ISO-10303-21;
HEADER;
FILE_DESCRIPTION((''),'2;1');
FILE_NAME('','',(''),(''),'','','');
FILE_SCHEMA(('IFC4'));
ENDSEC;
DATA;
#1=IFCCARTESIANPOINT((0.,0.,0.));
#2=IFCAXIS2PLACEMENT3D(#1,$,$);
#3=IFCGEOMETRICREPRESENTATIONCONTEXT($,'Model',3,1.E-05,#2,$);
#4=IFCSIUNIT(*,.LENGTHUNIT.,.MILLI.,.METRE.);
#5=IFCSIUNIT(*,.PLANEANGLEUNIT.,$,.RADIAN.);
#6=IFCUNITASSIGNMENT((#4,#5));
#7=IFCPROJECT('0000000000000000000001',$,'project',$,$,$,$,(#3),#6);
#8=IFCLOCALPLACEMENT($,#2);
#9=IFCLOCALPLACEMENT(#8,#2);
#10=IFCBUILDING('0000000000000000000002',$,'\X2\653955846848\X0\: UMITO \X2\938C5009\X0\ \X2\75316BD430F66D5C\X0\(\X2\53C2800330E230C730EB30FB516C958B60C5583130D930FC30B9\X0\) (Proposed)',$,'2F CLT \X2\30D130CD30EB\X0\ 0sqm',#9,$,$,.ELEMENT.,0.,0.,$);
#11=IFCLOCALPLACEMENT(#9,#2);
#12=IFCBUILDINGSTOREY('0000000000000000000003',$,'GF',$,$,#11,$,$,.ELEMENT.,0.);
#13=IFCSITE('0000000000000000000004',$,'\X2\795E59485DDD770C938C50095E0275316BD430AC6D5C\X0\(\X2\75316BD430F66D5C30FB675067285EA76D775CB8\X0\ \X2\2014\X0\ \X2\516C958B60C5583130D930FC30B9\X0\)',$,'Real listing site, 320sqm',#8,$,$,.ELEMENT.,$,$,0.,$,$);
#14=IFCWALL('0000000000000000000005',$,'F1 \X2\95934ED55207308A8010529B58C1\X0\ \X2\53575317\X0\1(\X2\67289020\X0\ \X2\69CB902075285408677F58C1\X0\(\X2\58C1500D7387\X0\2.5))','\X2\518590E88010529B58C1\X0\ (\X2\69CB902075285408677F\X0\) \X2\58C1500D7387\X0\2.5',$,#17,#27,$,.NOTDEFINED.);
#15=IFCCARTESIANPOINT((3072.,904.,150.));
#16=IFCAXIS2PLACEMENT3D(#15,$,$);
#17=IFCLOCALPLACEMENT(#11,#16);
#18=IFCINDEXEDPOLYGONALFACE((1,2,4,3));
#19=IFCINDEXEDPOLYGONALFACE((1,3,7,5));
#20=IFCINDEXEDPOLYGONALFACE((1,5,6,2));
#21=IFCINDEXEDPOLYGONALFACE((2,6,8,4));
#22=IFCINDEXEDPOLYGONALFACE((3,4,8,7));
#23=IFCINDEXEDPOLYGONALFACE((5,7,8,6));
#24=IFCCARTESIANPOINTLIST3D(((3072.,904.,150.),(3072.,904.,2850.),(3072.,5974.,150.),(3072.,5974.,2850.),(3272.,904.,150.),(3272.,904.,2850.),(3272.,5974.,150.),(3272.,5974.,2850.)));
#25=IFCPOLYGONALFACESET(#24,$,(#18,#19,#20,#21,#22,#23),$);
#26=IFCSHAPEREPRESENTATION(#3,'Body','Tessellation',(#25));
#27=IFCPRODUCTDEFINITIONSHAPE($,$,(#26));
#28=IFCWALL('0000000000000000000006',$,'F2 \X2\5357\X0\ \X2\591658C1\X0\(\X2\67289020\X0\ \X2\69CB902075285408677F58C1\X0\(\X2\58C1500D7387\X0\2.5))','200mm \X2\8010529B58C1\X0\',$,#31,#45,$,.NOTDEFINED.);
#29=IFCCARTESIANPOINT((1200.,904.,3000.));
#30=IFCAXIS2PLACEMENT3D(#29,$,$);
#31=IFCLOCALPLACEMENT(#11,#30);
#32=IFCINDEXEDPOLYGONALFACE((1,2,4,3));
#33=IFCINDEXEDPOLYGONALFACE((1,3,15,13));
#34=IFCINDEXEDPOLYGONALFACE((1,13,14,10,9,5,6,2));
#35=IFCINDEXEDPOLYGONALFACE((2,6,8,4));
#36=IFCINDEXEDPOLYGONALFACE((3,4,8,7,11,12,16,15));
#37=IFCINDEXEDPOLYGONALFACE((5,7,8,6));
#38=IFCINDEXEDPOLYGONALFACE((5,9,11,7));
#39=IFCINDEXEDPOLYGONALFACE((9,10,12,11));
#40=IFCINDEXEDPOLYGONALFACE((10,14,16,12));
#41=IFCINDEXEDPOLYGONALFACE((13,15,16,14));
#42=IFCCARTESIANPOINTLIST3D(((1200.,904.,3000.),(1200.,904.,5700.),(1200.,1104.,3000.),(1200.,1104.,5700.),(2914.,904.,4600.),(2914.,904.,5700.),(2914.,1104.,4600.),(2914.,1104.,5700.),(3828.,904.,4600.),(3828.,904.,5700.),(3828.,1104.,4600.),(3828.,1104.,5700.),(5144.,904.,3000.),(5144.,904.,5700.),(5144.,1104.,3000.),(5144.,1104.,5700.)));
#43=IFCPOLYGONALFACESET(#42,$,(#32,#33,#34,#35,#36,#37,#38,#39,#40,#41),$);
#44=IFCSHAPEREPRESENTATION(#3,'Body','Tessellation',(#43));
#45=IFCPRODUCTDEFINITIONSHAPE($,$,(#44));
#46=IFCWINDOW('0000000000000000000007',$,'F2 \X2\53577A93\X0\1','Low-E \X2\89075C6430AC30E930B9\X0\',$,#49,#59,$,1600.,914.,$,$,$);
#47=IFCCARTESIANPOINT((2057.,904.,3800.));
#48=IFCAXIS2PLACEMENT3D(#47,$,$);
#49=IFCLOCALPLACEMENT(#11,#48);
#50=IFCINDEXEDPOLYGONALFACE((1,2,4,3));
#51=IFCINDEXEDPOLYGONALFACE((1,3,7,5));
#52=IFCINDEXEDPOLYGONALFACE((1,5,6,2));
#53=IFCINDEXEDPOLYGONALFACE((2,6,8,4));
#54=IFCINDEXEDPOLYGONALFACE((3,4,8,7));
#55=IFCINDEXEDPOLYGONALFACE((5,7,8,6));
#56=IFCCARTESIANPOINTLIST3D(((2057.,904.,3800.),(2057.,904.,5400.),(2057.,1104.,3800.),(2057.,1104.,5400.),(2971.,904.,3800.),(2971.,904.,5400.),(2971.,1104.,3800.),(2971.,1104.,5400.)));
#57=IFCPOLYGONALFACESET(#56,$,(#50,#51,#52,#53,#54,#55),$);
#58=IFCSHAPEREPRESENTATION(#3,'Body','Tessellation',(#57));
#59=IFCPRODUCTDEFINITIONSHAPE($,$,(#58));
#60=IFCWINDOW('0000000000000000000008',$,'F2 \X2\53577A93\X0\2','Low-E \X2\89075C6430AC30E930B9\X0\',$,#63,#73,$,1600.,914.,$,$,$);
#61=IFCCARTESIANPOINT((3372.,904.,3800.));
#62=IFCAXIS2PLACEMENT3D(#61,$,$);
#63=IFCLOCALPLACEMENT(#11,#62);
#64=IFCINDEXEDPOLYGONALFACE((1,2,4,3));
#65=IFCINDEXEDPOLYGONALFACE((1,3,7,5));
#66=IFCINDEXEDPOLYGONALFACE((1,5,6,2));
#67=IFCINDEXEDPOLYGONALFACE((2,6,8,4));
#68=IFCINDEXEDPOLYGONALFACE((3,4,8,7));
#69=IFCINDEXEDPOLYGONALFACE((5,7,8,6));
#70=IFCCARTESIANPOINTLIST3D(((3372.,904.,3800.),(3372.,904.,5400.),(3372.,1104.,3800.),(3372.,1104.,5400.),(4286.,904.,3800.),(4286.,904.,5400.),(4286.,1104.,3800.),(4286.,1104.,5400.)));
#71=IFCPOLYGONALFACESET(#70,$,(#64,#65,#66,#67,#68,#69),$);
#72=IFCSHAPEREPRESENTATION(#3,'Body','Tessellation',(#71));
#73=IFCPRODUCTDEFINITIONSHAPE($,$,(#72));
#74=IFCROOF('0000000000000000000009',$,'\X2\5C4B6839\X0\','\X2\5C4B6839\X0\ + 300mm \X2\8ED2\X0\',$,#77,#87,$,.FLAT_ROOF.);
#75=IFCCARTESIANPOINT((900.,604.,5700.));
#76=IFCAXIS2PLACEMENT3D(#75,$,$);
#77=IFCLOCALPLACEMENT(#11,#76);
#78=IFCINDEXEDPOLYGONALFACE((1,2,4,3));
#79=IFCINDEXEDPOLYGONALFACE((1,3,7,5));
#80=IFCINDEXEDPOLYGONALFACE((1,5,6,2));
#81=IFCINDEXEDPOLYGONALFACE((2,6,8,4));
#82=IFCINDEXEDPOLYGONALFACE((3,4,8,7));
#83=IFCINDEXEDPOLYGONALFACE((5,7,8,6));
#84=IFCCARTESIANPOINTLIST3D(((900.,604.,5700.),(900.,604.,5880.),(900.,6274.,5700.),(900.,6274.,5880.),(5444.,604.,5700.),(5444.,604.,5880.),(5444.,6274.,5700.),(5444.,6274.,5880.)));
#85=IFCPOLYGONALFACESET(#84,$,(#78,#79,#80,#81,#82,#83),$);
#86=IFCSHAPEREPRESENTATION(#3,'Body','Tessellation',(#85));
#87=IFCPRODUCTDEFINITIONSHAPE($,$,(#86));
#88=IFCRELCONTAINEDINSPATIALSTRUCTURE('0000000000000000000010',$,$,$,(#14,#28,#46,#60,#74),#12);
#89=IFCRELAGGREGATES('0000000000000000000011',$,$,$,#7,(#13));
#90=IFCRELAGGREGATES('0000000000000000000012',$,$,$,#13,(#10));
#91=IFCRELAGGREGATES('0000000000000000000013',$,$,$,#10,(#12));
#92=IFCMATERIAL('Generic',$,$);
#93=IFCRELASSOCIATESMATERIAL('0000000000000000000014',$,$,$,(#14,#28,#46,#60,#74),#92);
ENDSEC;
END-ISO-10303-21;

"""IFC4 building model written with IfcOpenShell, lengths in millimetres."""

from ifc_helpers import new_model, si_unit, frame, frame_2d, origin, place, context, project, spatial, rectangle, extrude, material, element, fill, save


model = new_model("IFC4")

# Units and contexts
model_context = context("Model", 3, precision=1e-05, world=origin())
ifc_project = project(units=[si_unit("LENGTHUNIT", "METRE", prefix="MILLI"), si_unit("PLANEANGLEUNIT", "RADIAN")], contexts=[model_context])

# Site, building, storey
site_placement = place(None, origin())
site = spatial("IfcSite", under=ifc_project, at=site_placement, Name="神奈川県鎌倉市由比ガ浜(由比ヶ浜・材木座海岸 — 公開情報ベース)", ObjectType="Real listing site, 320sqm", CompositionType="ELEMENT", RefElevation=0.0)
building_placement = place(site_placement, origin())
building = spatial("IfcBuilding", under=site, at=building_placement, Name="改善案: UMITO 鎌倉 由比ヶ浜(参考モデル・公開情報ベース) (Proposed)", ObjectType="2F CLT パネル 0sqm", CompositionType="ELEMENT", ElevationOfRefHeight=0.0, ElevationOfTerrain=0.0)
storey_placement = place(building_placement, origin())
storey = spatial("IfcBuildingStorey", under=building, at=storey_placement, Name="GF", CompositionType="ELEMENT", Elevation=0.0)

# Shared definitions
ifc_material_1 = material(Name="Generic")

# Wall
wall_1_placement = place(storey_placement, frame((3072.0, 904.0, 150.0)))
element("IfcWall", 1, at=wall_1_placement, inside=storey, material=ifc_material_1, Name="F1 間仕切り耐力壁 南北1(木造 構造用合板壁(壁倍率2.5))", Description="内部耐力壁 (構造用合板) 壁倍率2.5", PredefinedType="NOTDEFINED", context=model_context, shape_type="SweptSolid", body=[
    extrude(rectangle(XDim=200.0, YDim=5070.0, at=frame_2d((100.0, 2535.0))), frame((3072.0, 904.0, 150.0)), (0.0, 0.0, 1.0), 2700.0),
])

# Wall, openings, windows
wall_2_placement = place(storey_placement, frame((1200.0, 904.0, 3000.0)))
wall_2 = element("IfcWall", 2, at=wall_2_placement, inside=storey, material=ifc_material_1, Name="F2 南 外壁(木造 構造用合板壁(壁倍率2.5))", Description="200mm 耐力壁", PredefinedType="NOTDEFINED", context=model_context, shape_type="SweptSolid", body=[
    extrude(rectangle(XDim=3944.0, YDim=200.0, at=frame_2d((1972.0, 100.0))), frame((1200.0, 904.0, 3000.0)), (0.0, 0.0, 1.0), 2700.0),
])
opening_1_placement = place(storey_placement, frame((2057.0, 904.0, 3800.0)))
opening_1 = element("IfcOpeningElement", 3, at=opening_1_placement, cuts=wall_2, PredefinedType="NOTDEFINED", context=model_context, shape_type="SweptSolid", body=[
    extrude(rectangle(XDim=914.0, YDim=200.0, at=frame_2d((457.0, 100.0))), frame((2057.0, 904.0, 3800.0)), (0.0, 0.0, 1.0), 1600.0),
])
opening_2_placement = place(storey_placement, frame((3372.0, 904.0, 3800.0)))
opening_2 = element("IfcOpeningElement", 4, at=opening_2_placement, cuts=wall_2, PredefinedType="NOTDEFINED", context=model_context, shape_type="SweptSolid", body=[
    extrude(rectangle(XDim=914.0, YDim=200.0, at=frame_2d((457.0, 100.0))), frame((3372.0, 904.0, 3800.0)), (0.0, 0.0, 1.0), 1600.0),
])
window_1_placement = place(storey_placement, frame((2057.0, 904.0, 3800.0)))
window_1 = element("IfcWindow", 5, at=window_1_placement, inside=storey, material=ifc_material_1, Name="F2 南窓1", Description="Low-E 複層ガラス", OverallHeight=1600.0, OverallWidth=914.0, context=model_context, shape_type="SweptSolid", body=[
    extrude(rectangle(XDim=914.0, YDim=200.0, at=frame_2d((457.0, 100.0))), frame((2057.0, 904.0, 3800.0)), (0.0, 0.0, 1.0), 1600.0),
])
fill(opening_1, window_1)
window_2_placement = place(storey_placement, frame((3372.0, 904.0, 3800.0)))
window_2 = element("IfcWindow", 6, at=window_2_placement, inside=storey, material=ifc_material_1, Name="F2 南窓2", Description="Low-E 複層ガラス", OverallHeight=1600.0, OverallWidth=914.0, context=model_context, shape_type="SweptSolid", body=[
    extrude(rectangle(XDim=914.0, YDim=200.0, at=frame_2d((457.0, 100.0))), frame((3372.0, 904.0, 3800.0)), (0.0, 0.0, 1.0), 1600.0),
])
fill(opening_2, window_2)

# Roof
roof_placement = place(storey_placement, frame((900.0, 604.0, 5700.0)))
element("IfcRoof", 7, at=roof_placement, inside=storey, material=ifc_material_1, Name="屋根", Description="屋根 + 300mm 軒", PredefinedType="FLAT_ROOF", context=model_context, shape_type="SweptSolid", body=[
    extrude(rectangle(XDim=4544.0, YDim=5670.0, at=frame_2d((2272.0, 2835.0))), frame((900.0, 604.0, 5700.0)), (0.0, 0.0, 1.0), 180.0),
])

save(model, "model.ifc")
